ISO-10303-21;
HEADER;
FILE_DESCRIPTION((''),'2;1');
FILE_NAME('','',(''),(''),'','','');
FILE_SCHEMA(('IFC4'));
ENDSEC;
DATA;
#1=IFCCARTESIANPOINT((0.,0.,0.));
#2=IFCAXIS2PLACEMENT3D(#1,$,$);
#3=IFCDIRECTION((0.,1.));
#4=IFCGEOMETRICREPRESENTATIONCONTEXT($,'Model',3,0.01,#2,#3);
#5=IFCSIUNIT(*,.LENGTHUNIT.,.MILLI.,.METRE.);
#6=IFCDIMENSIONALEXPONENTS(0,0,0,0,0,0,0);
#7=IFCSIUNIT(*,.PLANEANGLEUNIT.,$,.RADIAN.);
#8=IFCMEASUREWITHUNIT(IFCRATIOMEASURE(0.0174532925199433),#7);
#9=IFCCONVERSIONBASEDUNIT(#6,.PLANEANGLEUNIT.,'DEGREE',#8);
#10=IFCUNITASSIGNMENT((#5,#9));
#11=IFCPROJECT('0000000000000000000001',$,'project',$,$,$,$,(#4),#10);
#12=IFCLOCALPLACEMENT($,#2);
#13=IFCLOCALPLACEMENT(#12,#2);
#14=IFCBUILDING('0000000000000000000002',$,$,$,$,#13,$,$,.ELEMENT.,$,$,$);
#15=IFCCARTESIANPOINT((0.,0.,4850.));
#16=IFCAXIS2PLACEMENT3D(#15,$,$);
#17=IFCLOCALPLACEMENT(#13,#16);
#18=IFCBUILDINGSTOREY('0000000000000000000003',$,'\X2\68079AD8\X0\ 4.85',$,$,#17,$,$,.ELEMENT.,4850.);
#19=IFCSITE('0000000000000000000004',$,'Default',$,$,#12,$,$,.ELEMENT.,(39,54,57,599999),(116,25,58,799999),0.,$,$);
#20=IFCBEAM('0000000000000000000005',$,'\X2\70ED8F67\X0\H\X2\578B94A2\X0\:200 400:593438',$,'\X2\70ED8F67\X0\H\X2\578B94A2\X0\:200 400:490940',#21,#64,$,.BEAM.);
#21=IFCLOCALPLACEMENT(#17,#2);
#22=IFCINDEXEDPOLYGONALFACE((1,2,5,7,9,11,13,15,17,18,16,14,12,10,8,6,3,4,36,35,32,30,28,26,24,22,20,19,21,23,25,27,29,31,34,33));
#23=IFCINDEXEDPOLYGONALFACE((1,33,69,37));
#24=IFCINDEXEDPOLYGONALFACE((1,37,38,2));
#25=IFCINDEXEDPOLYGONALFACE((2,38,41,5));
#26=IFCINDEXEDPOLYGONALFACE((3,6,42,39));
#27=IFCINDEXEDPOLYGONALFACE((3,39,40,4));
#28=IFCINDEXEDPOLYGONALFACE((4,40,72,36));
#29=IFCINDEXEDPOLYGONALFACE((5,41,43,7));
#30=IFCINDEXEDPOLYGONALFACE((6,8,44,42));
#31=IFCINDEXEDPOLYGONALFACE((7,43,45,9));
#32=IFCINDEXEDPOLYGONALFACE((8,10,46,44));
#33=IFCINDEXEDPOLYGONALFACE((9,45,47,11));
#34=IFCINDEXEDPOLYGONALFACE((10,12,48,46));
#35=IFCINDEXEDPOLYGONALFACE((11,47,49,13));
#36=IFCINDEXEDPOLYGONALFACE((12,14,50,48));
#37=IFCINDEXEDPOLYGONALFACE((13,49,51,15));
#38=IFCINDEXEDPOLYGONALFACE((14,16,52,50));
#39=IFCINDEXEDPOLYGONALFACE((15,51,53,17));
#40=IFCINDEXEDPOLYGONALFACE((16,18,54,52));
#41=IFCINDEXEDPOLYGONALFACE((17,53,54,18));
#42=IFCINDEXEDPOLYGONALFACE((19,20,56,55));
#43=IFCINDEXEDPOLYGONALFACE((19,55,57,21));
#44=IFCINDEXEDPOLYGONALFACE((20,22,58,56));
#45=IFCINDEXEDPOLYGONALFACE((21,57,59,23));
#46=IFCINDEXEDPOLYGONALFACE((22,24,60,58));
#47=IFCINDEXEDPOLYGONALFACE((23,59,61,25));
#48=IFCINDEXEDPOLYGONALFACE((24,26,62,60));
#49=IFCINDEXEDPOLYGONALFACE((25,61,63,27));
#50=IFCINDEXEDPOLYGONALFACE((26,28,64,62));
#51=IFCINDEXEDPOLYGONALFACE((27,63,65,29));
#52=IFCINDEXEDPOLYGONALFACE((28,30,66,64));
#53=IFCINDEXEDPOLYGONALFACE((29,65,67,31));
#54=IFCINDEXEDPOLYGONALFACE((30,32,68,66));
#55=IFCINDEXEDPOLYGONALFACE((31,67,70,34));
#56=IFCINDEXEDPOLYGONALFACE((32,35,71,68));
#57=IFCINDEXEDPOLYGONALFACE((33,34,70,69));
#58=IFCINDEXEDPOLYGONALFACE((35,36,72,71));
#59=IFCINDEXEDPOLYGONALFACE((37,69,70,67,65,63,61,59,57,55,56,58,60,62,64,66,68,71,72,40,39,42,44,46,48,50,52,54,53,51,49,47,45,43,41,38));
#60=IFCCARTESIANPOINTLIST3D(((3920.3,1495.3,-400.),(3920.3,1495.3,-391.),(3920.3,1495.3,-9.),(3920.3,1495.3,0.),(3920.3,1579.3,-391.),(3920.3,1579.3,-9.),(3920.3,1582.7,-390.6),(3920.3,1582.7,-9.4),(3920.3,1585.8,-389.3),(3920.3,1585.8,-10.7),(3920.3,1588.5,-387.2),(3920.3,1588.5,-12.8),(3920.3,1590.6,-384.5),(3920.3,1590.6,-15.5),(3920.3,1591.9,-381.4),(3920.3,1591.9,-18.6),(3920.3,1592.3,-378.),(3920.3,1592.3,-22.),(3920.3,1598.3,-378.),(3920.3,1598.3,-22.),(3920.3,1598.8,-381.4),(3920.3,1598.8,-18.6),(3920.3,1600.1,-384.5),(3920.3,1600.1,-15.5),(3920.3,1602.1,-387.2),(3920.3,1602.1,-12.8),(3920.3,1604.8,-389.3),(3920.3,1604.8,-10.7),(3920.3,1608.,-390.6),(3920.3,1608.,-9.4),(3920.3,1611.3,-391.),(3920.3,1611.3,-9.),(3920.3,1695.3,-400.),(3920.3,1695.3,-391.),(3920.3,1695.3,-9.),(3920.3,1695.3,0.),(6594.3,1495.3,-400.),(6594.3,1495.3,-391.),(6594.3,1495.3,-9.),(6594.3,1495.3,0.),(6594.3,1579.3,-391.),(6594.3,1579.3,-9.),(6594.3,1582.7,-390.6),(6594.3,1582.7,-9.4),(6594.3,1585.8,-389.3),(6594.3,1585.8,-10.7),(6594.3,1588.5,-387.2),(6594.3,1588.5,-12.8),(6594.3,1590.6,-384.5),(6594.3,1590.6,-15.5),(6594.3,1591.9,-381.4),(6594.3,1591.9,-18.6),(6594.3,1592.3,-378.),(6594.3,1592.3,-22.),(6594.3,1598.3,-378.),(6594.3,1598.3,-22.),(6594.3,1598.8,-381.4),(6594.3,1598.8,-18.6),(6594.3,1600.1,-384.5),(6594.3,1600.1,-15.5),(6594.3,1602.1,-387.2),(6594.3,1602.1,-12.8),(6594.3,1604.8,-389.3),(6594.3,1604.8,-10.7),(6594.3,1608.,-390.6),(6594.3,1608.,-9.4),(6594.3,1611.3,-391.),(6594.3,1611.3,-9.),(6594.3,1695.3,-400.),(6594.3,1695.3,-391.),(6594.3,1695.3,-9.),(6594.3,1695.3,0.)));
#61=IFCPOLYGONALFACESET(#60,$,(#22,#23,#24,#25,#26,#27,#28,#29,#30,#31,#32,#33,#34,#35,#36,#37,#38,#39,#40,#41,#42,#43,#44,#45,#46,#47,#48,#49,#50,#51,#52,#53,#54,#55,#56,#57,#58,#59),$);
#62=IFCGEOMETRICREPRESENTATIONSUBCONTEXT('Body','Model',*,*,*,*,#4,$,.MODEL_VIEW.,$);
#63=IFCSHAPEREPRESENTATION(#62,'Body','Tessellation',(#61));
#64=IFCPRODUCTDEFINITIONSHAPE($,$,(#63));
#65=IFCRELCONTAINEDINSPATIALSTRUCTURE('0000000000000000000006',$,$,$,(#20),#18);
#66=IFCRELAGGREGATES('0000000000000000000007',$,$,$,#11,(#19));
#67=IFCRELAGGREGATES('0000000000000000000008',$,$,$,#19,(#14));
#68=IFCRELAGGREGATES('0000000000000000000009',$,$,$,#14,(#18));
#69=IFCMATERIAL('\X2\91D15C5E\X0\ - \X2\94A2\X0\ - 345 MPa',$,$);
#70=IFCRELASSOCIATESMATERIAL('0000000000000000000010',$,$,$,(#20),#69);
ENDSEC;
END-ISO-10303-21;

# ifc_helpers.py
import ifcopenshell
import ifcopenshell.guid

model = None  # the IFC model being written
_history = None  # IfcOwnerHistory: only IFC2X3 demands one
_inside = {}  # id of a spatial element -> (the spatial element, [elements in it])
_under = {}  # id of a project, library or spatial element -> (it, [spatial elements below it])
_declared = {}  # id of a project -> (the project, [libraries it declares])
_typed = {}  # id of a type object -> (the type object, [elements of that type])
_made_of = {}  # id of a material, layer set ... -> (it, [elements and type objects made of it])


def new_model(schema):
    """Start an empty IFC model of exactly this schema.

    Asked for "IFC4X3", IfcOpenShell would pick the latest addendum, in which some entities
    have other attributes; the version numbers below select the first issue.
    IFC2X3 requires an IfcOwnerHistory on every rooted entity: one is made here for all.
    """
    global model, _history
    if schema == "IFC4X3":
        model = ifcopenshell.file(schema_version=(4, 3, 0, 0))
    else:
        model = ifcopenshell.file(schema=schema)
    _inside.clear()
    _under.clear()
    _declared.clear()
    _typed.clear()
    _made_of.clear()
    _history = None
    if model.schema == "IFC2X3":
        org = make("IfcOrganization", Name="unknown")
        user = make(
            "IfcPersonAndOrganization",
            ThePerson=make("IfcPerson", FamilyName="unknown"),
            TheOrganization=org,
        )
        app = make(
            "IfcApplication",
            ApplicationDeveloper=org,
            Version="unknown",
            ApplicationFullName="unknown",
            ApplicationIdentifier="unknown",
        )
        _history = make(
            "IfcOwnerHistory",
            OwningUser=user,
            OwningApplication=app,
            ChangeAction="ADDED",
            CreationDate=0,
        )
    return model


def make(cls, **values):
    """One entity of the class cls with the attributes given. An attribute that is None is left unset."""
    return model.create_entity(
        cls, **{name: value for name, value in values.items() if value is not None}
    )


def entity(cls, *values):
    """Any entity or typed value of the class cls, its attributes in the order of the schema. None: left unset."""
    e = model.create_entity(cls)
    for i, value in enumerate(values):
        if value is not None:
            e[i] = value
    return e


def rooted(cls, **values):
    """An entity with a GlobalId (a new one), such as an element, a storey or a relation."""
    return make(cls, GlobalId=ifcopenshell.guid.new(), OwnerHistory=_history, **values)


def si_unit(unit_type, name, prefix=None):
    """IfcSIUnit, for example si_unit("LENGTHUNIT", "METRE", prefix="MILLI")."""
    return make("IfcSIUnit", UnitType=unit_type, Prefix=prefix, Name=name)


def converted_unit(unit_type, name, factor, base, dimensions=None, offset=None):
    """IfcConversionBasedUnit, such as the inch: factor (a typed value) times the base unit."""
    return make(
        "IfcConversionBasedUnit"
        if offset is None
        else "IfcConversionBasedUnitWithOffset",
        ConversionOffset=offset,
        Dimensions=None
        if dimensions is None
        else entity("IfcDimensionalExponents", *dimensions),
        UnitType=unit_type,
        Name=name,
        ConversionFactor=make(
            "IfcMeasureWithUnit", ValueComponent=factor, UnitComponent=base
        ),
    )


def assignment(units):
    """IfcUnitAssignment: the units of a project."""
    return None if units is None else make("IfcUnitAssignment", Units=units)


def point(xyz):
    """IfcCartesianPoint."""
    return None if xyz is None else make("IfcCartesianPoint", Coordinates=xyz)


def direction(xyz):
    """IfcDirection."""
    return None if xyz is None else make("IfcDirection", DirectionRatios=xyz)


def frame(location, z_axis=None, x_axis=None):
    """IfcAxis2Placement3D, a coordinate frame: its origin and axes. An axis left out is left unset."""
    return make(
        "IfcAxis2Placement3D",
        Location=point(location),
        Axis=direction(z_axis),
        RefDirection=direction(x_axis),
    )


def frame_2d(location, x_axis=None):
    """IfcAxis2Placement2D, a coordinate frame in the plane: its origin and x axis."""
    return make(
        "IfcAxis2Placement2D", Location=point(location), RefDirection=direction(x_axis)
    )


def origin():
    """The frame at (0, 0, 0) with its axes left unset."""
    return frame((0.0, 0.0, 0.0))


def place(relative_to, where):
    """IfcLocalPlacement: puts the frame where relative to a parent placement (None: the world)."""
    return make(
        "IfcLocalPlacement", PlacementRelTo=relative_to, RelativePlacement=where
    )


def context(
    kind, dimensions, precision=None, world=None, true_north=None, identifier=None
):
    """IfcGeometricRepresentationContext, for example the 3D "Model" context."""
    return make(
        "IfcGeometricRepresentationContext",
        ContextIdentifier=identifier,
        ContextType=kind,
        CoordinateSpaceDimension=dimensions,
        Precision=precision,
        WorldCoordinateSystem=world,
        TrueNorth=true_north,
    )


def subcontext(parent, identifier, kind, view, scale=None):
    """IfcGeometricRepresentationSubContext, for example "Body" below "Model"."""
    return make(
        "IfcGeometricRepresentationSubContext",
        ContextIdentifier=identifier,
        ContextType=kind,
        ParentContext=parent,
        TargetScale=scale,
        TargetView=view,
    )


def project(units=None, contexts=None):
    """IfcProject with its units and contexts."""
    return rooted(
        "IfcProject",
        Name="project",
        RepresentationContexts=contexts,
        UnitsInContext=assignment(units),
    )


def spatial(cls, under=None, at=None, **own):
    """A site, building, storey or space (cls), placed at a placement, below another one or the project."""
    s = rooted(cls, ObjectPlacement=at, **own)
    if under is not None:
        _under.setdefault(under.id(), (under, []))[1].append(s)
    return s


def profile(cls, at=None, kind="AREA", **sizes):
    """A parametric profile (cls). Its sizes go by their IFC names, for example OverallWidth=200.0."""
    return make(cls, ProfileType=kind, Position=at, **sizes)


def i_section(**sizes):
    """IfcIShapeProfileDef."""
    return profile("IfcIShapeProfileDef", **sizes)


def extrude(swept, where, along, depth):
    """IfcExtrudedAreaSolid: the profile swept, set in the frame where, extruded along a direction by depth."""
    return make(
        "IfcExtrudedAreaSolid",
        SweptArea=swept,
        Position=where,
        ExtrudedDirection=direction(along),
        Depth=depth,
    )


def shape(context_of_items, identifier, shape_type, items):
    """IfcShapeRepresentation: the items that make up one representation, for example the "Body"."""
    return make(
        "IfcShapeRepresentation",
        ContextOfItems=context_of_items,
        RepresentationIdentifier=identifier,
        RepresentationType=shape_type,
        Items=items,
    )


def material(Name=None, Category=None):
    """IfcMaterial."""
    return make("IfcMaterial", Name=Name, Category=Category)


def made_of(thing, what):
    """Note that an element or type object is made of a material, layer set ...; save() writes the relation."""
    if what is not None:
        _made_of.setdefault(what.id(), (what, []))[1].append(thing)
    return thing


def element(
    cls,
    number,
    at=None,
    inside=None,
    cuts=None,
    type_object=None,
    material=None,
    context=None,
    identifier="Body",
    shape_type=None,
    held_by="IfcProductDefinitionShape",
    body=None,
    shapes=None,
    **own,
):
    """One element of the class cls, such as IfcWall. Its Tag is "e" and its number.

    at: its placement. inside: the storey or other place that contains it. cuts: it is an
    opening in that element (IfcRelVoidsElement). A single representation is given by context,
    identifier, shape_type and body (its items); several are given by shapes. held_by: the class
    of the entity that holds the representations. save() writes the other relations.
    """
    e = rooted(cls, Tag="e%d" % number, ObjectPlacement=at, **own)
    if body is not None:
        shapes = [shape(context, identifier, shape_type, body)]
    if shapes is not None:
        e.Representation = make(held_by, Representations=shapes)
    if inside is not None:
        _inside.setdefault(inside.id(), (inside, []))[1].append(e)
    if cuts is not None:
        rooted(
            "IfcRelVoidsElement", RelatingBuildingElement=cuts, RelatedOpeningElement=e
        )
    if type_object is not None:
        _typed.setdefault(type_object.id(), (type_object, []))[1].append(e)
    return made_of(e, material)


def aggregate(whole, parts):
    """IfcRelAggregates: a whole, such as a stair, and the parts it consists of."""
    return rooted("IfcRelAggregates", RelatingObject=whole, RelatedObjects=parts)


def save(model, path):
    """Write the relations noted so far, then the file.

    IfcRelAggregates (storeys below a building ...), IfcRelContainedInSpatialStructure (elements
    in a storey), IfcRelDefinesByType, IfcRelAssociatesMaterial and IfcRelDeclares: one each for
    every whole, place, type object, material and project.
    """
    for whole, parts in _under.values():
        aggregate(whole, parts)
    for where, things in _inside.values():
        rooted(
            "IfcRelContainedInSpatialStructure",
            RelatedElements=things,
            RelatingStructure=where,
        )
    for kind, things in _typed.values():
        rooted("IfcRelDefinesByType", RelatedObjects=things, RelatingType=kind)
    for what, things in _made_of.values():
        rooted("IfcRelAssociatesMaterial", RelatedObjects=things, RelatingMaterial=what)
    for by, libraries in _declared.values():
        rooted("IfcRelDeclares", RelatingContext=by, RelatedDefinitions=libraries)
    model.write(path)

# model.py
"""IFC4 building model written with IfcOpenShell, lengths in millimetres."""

from ifc_helpers import new_model, entity, si_unit, converted_unit, direction, frame, frame_2d, origin, place, context, subcontext, project, spatial, i_section, extrude, material, element, save


model = new_model("IFC4")

# Units and contexts
model_context = context("Model", 3, precision=0.01, world=origin(), true_north=direction((0.0, 1.0)))
body_context = subcontext(model_context, "Body", "Model", "MODEL_VIEW")
ifc_project = project(units=[si_unit("LENGTHUNIT", "METRE", prefix="MILLI"), converted_unit("PLANEANGLEUNIT", "DEGREE", entity("IfcRatioMeasure", 0.0174532925199433), si_unit("PLANEANGLEUNIT", "RADIAN"), dimensions=[0, 0, 0, 0, 0, 0, 0])], contexts=[model_context])

# Site, building, storey
site_placement = place(None, origin())
site = spatial("IfcSite", under=ifc_project, at=site_placement, Name="Default", CompositionType="ELEMENT", RefLatitude=(39, 54, 57, 599999), RefLongitude=(116, 25, 58, 799999), RefElevation=0.0)
building_placement = place(site_placement, origin())
building = spatial("IfcBuilding", under=site, at=building_placement, CompositionType="ELEMENT")
storey_placement = place(building_placement, frame((0.0, 0.0, 4850.0)))
storey = spatial("IfcBuildingStorey", under=building, at=storey_placement, Name="标高 4.85", CompositionType="ELEMENT", Elevation=4850.0)

# Beam
ifc_material_1 = material(Name="金属 - 钢 - 345 MPa")
beam_1_placement = place(storey_placement, frame((3757.3, 1595.3, 0.0)))
element("IfcBeam", 1, at=beam_1_placement, inside=storey, material=ifc_material_1, Name="热轧H型钢:200 400:593438", ObjectType="热轧H型钢:200 400:490940", PredefinedType="BEAM", context=body_context, shape_type="SweptSolid", body=[
    extrude(i_section(OverallWidth=200.0, OverallDepth=400.0, WebThickness=6.0, FlangeThickness=9.0, FilletRadius=13.0, at=frame_2d((0.0, 0.0), x_axis=(0.0, 1.0))), frame((163.0, 0.0, -200.0), z_axis=(1.0, 0.0, 0.0), x_axis=(0.0, 0.0, -1.0)), (0.0, 0.0, 1.0), 2674.0),
])

save(model, "model.ifc")
